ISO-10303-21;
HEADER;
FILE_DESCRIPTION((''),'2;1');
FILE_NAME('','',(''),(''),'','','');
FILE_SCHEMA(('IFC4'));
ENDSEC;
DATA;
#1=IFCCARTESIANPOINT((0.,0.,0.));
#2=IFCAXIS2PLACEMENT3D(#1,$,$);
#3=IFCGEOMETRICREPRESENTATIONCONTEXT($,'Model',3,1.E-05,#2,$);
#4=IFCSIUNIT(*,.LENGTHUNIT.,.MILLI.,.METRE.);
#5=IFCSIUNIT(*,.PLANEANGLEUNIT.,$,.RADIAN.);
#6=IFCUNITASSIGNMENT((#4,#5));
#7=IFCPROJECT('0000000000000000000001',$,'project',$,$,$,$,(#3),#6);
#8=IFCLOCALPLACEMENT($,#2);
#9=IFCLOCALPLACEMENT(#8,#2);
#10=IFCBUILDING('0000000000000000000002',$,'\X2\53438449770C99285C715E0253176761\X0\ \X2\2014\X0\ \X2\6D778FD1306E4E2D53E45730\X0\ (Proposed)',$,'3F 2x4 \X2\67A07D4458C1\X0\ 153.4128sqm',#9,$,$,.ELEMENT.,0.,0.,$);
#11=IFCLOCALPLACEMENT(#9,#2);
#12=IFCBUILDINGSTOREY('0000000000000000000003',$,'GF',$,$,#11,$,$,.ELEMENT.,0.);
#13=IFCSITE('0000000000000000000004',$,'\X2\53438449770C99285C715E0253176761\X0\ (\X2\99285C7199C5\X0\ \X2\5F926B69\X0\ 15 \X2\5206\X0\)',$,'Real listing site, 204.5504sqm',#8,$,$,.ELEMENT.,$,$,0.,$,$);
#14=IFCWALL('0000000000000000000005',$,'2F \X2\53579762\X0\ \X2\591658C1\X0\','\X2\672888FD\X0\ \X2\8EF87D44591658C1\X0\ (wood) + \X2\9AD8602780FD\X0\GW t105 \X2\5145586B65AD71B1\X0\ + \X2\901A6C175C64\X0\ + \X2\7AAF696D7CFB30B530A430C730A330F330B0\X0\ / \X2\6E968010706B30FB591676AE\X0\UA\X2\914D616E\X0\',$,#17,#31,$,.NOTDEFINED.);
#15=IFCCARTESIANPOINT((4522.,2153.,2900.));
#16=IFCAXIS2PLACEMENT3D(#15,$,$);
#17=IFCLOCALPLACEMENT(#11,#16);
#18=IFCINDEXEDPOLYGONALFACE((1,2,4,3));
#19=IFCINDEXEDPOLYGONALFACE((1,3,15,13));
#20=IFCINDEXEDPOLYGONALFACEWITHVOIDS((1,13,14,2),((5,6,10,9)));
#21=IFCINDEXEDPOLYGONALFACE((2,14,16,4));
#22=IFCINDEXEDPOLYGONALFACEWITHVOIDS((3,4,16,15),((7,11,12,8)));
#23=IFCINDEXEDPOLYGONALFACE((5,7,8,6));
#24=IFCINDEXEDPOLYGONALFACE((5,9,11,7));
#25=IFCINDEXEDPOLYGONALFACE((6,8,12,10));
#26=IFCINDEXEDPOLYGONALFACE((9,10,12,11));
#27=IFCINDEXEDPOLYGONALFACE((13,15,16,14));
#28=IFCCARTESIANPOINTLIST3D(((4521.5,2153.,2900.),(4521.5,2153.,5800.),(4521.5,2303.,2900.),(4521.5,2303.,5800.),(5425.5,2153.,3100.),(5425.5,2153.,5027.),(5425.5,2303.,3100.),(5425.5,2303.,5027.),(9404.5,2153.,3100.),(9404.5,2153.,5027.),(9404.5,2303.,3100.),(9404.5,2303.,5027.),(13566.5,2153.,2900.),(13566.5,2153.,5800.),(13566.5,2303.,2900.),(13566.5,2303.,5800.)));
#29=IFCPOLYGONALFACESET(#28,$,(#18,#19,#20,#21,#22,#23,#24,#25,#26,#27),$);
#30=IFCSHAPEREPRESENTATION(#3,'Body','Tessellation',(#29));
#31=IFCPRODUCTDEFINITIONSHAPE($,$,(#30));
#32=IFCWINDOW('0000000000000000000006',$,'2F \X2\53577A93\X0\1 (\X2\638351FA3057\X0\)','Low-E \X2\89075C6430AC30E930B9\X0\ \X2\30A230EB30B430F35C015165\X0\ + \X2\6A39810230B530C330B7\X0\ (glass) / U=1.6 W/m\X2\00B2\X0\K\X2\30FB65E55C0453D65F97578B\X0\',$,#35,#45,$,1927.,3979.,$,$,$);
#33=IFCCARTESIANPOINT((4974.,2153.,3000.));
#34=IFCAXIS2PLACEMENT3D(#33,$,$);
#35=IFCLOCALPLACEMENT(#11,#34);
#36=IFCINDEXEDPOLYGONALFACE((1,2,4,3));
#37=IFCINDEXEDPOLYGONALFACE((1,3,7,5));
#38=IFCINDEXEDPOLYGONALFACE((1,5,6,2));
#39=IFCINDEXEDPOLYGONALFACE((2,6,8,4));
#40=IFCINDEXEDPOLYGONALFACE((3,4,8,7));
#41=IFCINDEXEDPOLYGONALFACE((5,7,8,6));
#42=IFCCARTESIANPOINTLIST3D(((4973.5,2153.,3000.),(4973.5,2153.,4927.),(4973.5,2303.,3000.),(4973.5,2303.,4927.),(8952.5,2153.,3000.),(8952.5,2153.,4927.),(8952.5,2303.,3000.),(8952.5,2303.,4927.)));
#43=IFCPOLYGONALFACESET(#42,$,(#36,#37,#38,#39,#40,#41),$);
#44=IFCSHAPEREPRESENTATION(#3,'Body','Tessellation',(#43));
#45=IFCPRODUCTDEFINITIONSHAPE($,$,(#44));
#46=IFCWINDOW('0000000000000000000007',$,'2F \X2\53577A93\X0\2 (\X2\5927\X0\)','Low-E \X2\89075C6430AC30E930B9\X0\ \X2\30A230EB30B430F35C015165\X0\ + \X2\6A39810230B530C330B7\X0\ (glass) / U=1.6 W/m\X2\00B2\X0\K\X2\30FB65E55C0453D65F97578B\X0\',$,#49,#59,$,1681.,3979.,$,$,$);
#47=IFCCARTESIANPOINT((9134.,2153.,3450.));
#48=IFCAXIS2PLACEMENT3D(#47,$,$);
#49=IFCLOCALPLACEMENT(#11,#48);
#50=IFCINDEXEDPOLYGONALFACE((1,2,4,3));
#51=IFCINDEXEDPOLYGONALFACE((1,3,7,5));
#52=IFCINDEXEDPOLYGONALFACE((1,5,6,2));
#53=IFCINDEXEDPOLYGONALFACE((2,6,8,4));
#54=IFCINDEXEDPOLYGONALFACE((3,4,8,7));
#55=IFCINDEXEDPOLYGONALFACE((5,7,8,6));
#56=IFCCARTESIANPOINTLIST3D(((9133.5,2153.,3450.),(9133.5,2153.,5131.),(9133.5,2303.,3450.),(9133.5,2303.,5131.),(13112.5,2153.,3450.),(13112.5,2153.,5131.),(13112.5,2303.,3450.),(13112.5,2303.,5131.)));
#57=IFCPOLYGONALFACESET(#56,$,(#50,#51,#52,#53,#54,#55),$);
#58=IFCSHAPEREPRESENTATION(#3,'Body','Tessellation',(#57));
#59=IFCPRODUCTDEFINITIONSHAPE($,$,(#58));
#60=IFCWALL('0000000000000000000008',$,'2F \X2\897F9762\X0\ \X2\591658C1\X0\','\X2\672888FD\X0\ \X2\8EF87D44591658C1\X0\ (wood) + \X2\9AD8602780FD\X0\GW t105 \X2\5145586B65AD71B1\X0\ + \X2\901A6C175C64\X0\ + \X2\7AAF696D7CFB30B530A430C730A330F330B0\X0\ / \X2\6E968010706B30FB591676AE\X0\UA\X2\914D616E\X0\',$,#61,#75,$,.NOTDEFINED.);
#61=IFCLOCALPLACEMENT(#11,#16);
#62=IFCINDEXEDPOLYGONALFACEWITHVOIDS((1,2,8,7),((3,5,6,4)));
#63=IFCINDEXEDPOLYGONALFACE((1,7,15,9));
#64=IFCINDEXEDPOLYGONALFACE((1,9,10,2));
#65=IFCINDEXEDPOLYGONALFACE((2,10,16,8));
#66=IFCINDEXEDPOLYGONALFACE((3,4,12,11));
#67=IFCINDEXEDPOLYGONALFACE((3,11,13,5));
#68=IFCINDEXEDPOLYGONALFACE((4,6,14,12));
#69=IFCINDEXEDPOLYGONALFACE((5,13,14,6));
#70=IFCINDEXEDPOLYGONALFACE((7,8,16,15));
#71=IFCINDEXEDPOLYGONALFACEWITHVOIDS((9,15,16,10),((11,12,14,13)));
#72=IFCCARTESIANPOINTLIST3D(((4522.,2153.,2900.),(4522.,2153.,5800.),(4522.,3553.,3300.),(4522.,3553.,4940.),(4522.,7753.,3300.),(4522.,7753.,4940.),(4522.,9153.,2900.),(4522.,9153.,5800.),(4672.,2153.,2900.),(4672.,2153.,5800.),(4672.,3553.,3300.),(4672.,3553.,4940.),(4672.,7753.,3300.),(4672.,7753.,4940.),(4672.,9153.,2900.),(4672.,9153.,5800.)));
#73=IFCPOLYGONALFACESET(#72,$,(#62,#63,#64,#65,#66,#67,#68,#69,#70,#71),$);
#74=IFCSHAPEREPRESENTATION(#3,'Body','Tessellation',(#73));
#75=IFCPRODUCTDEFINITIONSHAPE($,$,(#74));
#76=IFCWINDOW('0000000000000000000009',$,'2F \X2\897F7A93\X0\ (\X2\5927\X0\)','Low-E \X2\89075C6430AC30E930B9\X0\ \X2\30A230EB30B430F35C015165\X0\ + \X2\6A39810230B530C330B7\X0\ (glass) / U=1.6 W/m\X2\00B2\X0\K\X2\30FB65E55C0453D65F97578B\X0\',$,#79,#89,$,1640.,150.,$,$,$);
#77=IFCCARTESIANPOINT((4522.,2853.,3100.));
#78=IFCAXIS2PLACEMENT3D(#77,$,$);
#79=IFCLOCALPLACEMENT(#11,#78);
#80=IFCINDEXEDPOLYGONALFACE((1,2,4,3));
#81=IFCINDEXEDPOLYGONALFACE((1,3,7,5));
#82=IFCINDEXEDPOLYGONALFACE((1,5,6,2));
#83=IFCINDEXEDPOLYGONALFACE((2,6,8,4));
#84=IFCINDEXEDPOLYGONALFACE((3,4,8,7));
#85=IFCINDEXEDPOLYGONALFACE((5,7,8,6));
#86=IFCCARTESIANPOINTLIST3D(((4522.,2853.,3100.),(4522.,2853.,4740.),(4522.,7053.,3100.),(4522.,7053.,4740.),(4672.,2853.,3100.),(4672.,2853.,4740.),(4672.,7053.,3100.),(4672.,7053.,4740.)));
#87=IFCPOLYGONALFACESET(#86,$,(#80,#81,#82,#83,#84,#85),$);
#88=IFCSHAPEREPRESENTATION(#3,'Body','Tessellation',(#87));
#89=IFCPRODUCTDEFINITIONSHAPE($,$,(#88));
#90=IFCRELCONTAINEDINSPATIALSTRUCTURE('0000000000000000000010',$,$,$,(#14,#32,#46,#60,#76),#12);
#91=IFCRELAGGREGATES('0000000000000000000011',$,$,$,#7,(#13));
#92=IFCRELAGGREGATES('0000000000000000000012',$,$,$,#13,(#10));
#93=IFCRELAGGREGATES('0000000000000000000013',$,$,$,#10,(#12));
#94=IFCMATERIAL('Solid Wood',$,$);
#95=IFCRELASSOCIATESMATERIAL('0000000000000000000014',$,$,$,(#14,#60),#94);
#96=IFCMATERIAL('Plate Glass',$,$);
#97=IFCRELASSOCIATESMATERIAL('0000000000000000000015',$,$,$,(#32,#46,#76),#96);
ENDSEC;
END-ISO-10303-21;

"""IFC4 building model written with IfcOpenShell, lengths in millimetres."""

from ifc_helpers import new_model, si_unit, frame, frame_2d, origin, place, context, project, spatial, rectangle, extrude, material, element, fill, save


model = new_model("IFC4")

# Units and contexts
model_context = context("Model", 3, precision=1e-05, world=origin())
ifc_project = project(units=[si_unit("LENGTHUNIT", "METRE", prefix="MILLI"), si_unit("PLANEANGLEUNIT", "RADIAN")], contexts=[model_context])

# Site, building, storey
site_placement = place(None, origin())
site = spatial("IfcSite", under=ifc_project, at=site_placement, Name="千葉県館山市北条 (館山駅 徒歩 15 分)", ObjectType="Real listing site, 204.5504sqm", CompositionType="ELEMENT", RefElevation=0.0)
building_placement = place(site_placement, origin())
building = spatial("IfcBuilding", under=site, at=building_placement, Name="千葉県館山市北条 — 海近の中古地 (Proposed)", ObjectType="3F 2x4 枠組壁 153.4128sqm", CompositionType="ELEMENT", ElevationOfRefHeight=0.0, ElevationOfTerrain=0.0)
storey_placement = place(building_placement, origin())
storey = spatial("IfcBuildingStorey", under=building, at=storey_placement, Name="GF", CompositionType="ELEMENT", Elevation=0.0)

# Shared definitions
ifc_material_1 = material(Name="Solid Wood")

# Shared definitions
ifc_material_2 = material(Name="Plate Glass")

# Wall, openings, windows
wall_1_placement = place(storey_placement, frame((4522.0, 2153.0, 2900.0)))
wall_1 = element("IfcWall", 1, at=wall_1_placement, inside=storey, material=ifc_material_1, Name="2F 南面 外壁", Description="木製 軸組外壁 (wood) + 高性能GW t105 充填断熱 + 通気層 + 窯業系サイディング / 準耐火・外皮UA配慮", PredefinedType="NOTDEFINED", context=model_context, shape_type="SweptSolid", body=[
    extrude(rectangle(XDim=9045.0, YDim=150.0, at=frame_2d((4522.0, 75.0))), frame((4522.0, 2153.0, 2900.0)), (0.0, 0.0, 1.0), 2900.0),
])
opening_1_placement = place(storey_placement, frame((4974.0, 2153.0, 3000.0)))
opening_1 = element("IfcOpeningElement", 2, at=opening_1_placement, cuts=wall_1, PredefinedType="NOTDEFINED", context=model_context, shape_type="SweptSolid", body=[
    extrude(rectangle(XDim=3979.0, YDim=150.0, at=frame_2d((1989.0, 75.0))), frame((4974.0, 2153.0, 3000.0)), (0.0, 0.0, 1.0), 1927.0),
])
opening_2_placement = place(storey_placement, frame((9134.0, 2153.0, 3450.0)))
opening_2 = element("IfcOpeningElement", 3, at=opening_2_placement, cuts=wall_1, PredefinedType="NOTDEFINED", context=model_context, shape_type="SweptSolid", body=[
    extrude(rectangle(XDim=3979.0, YDim=150.0, at=frame_2d((1989.0, 75.0))), frame((9134.0, 2153.0, 3450.0)), (0.0, 0.0, 1.0), 1681.0),
])
window_1_placement = place(storey_placement, frame((4974.0, 2153.0, 3000.0)))
window_1 = element("IfcWindow", 4, at=window_1_placement, inside=storey, material=ifc_material_2, Name="2F 南窓1 (掃出し)", Description="Low-E 複層ガラス アルゴン封入 + 樹脂サッシ (glass) / U=1.6 W/m²K・日射取得型", OverallHeight=1927.0, OverallWidth=3979.0, context=model_context, shape_type="SweptSolid", body=[
    extrude(rectangle(XDim=3979.0, YDim=150.0, at=frame_2d((1989.0, 75.0))), frame((4974.0, 2153.0, 3000.0)), (0.0, 0.0, 1.0), 1927.0),
])
fill(opening_1, window_1)
window_2_placement = place(storey_placement, frame((9134.0, 2153.0, 3450.0)))
window_2 = element("IfcWindow", 5, at=window_2_placement, inside=storey, material=ifc_material_2, Name="2F 南窓2 (大)", Description="Low-E 複層ガラス アルゴン封入 + 樹脂サッシ (glass) / U=1.6 W/m²K・日射取得型", OverallHeight=1681.0, OverallWidth=3979.0, context=model_context, shape_type="SweptSolid", body=[
    extrude(rectangle(XDim=3979.0, YDim=150.0, at=frame_2d((1989.0, 75.0))), frame((9134.0, 2153.0, 3450.0)), (0.0, 0.0, 1.0), 1681.0),
])
fill(opening_2, window_2)

# Wall, opening, window
wall_2_placement = place(storey_placement, frame((4522.0, 2153.0, 2900.0)))
wall_2 = element("IfcWall", 6, at=wall_2_placement, inside=storey, material=ifc_material_1, Name="2F 西面 外壁", Description="木製 軸組外壁 (wood) + 高性能GW t105 充填断熱 + 通気層 + 窯業系サイディング / 準耐火・外皮UA配慮", PredefinedType="NOTDEFINED", context=model_context, shape_type="SweptSolid", body=[
    extrude(rectangle(XDim=150.0, YDim=7000.0, at=frame_2d((75.0, 3500.0))), frame((4522.0, 2153.0, 2900.0)), (0.0, 0.0, 1.0), 2900.0),
])
opening_3_placement = place(storey_placement, frame((4522.0, 2853.0, 3100.0)))
opening_3 = element("IfcOpeningElement", 7, at=opening_3_placement, cuts=wall_2, PredefinedType="NOTDEFINED", context=model_context, shape_type="SweptSolid", body=[
    extrude(rectangle(XDim=150.0, YDim=4200.0, at=frame_2d((75.0, 2100.0))), frame((4522.0, 2853.0, 3100.0)), (0.0, 0.0, 1.0), 1640.0),
])
window_3_placement = place(storey_placement, frame((4522.0, 2853.0, 3100.0)))
window_3 = element("IfcWindow", 8, at=window_3_placement, inside=storey, material=ifc_material_2, Name="2F 西窓 (大)", Description="Low-E 複層ガラス アルゴン封入 + 樹脂サッシ (glass) / U=1.6 W/m²K・日射取得型", OverallHeight=1640.0, OverallWidth=150.0, context=model_context, shape_type="SweptSolid", body=[
    extrude(rectangle(XDim=150.0, YDim=4200.0, at=frame_2d((75.0, 2100.0))), frame((4522.0, 2853.0, 3100.0)), (0.0, 0.0, 1.0), 1640.0),
])
fill(opening_3, window_3)

save(model, "model.ifc")
